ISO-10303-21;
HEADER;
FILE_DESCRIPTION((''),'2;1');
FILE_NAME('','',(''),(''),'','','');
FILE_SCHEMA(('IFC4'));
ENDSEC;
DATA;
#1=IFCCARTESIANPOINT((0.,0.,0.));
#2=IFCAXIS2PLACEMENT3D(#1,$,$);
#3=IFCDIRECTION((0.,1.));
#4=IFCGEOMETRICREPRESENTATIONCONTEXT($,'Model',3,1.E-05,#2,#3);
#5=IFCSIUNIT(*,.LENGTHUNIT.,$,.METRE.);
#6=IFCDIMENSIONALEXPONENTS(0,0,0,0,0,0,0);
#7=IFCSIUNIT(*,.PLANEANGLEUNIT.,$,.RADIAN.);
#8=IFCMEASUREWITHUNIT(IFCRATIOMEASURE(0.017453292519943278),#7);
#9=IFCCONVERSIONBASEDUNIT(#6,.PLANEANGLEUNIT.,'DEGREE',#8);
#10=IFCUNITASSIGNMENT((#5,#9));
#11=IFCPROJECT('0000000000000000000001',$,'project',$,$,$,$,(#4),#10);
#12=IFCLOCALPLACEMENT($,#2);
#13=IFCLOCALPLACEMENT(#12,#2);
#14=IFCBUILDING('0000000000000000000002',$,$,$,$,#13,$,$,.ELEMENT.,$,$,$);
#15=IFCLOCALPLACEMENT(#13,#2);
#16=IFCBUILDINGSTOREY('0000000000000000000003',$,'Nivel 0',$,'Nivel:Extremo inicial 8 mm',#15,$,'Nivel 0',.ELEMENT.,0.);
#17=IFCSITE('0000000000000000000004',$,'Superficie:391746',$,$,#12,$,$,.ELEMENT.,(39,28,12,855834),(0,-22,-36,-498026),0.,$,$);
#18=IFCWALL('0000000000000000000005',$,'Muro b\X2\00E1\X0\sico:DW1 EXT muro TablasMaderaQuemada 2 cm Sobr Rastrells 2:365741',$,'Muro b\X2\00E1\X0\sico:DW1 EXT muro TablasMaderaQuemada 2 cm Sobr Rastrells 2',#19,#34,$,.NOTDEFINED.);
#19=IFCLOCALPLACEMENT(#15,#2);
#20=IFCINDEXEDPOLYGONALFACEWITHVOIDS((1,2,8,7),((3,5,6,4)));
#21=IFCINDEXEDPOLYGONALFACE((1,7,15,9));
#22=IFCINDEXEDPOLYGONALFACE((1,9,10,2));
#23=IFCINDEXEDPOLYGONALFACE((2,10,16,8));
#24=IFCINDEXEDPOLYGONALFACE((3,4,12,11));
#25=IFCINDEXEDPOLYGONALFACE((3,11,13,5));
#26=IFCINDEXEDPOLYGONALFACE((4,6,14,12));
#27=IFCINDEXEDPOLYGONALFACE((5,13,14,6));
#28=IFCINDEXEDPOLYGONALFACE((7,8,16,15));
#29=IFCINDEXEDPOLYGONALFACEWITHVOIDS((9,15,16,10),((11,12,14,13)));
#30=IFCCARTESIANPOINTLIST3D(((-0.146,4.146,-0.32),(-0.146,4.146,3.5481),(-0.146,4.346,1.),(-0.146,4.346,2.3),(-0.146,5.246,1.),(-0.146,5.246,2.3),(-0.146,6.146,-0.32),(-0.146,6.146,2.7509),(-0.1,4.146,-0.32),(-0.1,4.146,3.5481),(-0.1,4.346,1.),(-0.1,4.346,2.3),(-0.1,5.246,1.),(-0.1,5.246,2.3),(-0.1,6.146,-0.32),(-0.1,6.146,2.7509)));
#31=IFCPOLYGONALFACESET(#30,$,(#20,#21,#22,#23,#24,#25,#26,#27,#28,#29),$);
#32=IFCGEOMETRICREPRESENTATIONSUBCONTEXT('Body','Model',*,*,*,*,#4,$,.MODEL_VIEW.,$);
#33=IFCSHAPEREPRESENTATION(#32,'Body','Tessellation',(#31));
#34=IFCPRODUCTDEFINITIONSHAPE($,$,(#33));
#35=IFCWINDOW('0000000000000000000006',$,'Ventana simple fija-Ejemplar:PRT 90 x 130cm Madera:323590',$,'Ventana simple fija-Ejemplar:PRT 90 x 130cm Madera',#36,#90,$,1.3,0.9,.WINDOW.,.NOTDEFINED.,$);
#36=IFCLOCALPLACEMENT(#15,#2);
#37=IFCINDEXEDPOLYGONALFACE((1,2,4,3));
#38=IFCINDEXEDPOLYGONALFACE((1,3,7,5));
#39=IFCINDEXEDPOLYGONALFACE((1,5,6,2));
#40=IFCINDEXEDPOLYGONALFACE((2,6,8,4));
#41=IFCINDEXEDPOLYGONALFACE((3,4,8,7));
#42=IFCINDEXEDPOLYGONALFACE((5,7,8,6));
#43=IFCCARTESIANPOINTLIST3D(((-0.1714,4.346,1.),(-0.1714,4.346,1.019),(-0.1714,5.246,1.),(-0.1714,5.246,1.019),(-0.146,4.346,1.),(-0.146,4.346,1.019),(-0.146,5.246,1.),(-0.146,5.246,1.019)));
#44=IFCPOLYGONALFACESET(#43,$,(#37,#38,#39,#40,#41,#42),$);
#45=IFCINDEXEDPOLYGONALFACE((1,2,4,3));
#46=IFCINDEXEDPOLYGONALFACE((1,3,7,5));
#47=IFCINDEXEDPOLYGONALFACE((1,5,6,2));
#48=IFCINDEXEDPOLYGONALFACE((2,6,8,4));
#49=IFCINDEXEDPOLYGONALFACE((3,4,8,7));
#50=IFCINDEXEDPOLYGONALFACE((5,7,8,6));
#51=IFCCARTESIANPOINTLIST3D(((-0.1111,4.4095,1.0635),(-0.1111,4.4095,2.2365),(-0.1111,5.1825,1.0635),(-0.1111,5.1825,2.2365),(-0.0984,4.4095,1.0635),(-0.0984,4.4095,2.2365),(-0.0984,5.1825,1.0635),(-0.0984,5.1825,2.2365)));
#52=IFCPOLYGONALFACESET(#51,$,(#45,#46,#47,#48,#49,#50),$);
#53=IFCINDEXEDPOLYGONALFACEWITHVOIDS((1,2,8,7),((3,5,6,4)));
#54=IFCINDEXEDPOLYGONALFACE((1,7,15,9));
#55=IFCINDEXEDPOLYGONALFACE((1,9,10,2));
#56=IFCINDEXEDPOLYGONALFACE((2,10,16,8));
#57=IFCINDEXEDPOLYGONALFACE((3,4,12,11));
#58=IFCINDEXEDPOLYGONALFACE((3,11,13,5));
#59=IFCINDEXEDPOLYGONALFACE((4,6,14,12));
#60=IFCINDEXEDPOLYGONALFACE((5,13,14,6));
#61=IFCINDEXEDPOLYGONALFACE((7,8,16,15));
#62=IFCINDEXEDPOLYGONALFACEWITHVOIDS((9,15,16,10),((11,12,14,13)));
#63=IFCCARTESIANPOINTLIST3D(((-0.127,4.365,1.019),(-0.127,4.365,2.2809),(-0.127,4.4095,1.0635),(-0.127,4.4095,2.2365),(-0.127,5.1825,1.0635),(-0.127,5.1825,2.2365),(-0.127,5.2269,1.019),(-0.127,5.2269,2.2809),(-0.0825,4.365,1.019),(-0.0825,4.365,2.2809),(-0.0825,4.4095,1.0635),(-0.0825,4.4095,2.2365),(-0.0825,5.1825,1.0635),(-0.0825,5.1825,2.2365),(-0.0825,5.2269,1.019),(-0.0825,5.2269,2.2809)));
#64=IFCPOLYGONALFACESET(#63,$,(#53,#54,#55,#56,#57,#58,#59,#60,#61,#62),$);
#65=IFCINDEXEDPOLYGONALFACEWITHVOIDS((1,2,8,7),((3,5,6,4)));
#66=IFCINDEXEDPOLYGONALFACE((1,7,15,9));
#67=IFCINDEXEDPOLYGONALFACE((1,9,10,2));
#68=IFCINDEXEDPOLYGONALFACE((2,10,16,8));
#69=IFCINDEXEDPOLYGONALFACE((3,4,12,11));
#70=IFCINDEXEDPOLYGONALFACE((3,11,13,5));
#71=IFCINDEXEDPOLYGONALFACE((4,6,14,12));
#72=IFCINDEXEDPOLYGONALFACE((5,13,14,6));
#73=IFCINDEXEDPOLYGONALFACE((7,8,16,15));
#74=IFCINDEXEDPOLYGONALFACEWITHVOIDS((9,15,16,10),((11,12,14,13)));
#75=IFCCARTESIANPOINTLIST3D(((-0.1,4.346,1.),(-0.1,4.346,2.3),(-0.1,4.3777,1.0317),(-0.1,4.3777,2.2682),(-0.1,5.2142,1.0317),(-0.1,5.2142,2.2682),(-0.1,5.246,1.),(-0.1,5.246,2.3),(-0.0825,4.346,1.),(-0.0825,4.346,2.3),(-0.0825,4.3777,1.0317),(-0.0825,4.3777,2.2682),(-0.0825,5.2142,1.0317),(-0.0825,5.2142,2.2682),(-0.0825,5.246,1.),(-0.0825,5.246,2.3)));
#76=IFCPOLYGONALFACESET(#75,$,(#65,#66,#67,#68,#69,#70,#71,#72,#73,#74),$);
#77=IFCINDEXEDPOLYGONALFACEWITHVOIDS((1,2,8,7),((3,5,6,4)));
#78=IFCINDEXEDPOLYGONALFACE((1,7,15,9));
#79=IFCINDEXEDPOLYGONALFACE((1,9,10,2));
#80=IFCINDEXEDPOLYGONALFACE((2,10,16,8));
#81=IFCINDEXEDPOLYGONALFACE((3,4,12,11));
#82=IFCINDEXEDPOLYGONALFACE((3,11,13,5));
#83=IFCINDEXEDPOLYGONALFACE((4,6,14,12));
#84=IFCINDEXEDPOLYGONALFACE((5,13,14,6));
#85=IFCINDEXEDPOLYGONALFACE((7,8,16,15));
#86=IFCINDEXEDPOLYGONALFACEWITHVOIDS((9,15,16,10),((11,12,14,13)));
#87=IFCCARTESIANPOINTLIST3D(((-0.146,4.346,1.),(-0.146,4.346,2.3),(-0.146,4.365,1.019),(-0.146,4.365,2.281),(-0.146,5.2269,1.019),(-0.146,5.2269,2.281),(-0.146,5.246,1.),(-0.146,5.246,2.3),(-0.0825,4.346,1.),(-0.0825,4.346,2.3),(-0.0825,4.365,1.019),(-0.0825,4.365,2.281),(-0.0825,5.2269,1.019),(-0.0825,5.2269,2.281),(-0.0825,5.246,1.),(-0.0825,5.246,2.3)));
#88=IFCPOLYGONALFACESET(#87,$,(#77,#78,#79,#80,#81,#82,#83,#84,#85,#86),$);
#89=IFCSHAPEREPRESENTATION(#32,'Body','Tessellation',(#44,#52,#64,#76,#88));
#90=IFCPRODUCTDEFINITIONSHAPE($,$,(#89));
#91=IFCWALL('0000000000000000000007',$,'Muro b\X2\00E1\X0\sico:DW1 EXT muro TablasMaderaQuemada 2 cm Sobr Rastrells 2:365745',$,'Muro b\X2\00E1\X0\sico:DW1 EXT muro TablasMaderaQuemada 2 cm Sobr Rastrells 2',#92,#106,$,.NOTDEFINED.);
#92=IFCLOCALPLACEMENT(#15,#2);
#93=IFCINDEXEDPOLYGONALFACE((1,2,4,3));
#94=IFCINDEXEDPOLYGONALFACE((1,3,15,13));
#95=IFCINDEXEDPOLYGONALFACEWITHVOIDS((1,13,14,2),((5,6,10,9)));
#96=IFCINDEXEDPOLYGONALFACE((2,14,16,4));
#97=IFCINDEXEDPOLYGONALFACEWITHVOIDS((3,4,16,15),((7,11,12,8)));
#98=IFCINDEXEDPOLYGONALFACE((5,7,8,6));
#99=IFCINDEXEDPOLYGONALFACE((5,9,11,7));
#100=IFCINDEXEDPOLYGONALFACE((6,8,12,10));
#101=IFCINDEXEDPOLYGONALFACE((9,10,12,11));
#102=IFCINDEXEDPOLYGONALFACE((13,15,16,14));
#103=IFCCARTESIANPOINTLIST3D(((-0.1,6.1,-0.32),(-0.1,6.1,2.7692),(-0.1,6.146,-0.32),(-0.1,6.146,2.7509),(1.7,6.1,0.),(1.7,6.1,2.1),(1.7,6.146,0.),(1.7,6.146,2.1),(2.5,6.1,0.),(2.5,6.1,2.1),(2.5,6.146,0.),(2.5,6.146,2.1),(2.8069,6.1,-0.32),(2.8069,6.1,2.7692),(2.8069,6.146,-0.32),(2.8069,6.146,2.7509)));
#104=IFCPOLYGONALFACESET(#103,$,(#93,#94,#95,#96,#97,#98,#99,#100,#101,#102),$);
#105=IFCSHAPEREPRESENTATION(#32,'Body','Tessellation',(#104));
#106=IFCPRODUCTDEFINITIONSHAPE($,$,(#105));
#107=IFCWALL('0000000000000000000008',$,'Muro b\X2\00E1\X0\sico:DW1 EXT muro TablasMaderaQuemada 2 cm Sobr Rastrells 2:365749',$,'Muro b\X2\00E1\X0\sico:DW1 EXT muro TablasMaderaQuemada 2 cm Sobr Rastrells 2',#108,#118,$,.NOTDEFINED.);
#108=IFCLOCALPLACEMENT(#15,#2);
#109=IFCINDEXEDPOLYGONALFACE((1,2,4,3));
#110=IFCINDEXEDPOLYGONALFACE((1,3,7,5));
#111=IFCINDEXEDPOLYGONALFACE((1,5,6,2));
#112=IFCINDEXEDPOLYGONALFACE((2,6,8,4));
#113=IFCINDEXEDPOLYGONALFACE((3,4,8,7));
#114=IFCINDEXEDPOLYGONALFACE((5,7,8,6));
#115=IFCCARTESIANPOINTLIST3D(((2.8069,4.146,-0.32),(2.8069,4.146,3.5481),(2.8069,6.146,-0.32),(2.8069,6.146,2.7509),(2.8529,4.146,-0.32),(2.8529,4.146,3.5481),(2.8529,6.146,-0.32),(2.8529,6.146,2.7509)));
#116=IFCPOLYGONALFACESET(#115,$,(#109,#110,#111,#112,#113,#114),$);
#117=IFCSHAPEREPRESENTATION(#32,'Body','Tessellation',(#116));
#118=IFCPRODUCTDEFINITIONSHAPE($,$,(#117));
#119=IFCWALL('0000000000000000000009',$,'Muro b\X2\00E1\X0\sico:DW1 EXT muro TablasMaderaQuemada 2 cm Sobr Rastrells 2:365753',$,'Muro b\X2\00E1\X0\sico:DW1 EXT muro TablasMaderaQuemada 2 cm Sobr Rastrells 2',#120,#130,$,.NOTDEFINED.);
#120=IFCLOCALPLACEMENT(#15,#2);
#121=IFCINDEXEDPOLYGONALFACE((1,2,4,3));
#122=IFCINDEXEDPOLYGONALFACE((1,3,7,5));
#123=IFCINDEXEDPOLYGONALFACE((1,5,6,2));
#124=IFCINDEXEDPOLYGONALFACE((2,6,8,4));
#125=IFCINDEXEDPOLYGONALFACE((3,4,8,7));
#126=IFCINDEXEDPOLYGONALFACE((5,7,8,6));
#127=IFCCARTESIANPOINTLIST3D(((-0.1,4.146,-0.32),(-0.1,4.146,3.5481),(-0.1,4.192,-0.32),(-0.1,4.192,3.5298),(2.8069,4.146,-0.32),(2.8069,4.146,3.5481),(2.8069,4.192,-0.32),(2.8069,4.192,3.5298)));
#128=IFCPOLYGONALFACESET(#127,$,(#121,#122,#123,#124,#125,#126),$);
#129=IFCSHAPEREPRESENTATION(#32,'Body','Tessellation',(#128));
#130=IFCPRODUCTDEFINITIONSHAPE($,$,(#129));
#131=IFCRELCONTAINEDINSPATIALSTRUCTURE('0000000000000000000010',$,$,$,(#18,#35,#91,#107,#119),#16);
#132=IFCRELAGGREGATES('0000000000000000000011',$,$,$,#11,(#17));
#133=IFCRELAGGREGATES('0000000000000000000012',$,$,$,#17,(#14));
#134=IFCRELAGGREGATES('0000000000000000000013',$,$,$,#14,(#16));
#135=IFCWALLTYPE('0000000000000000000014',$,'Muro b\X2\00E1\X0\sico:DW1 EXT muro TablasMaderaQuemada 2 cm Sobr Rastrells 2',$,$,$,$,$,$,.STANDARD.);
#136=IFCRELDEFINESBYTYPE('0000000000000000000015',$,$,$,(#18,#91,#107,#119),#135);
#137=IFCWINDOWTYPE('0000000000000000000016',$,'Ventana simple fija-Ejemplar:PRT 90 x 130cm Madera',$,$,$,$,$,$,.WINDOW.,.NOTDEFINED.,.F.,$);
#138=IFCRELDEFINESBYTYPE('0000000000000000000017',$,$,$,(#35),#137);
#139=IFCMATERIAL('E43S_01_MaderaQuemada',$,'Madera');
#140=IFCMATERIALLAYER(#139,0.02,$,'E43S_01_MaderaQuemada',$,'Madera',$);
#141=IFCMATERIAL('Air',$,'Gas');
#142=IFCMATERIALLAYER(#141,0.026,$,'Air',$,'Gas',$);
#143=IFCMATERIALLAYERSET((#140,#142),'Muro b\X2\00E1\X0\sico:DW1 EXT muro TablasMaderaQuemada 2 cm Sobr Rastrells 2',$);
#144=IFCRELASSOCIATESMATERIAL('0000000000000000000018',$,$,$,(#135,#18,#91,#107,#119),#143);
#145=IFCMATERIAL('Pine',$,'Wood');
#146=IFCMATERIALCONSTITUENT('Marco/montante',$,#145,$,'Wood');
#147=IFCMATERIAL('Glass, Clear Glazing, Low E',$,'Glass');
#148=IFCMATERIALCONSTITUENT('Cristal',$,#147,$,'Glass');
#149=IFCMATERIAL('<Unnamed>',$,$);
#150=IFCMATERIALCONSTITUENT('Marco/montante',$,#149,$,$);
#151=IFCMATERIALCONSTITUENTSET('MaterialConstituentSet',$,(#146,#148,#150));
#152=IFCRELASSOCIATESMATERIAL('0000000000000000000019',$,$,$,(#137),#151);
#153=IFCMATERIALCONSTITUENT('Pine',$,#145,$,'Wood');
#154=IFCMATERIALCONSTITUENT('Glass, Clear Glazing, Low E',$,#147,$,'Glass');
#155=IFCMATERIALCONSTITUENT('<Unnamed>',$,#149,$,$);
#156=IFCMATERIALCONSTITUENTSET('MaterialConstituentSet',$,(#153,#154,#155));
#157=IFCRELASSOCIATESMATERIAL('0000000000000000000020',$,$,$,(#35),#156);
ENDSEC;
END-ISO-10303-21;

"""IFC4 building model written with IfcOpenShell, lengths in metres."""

from ifc_helpers import new_model, entity, si_unit, converted_unit, direction, frame, frame_2d, origin, origin_2d_with_axis, place, context, subcontext, project, spatial, polyline, rectangle, outline, extrude, clip, bounded_halfspace, source, transform, mapped, material, layer, layer_set, layer_usage, constituent, constituent_set, type_object, type_shapes, element, fill, save


model = new_model("IFC4")

# Units and contexts
model_context = context("Model", 3, precision=1e-05, world=origin(), true_north=direction((0.0, 1.0)))
body_context = subcontext(model_context, "Body", "Model", "MODEL_VIEW")
ifc_project = project(units=[si_unit("LENGTHUNIT", "METRE"), converted_unit("PLANEANGLEUNIT", "DEGREE", entity("IfcRatioMeasure", 0.017453292519943278), si_unit("PLANEANGLEUNIT", "RADIAN"), dimensions=[0, 0, 0, 0, 0, 0, 0])], contexts=[model_context])

# Site, building, storey
site_placement = place(None, origin())
site = spatial("IfcSite", under=ifc_project, at=site_placement, Name="Superficie:391746", CompositionType="ELEMENT", RefLatitude=(39, 28, 12, 855834), RefLongitude=(0, -22, -36, -498026), RefElevation=0.0)
building_placement = place(site_placement, origin())
building = spatial("IfcBuilding", under=site, at=building_placement, CompositionType="ELEMENT")
storey_placement = place(building_placement, origin())
storey = spatial("IfcBuildingStorey", under=building, at=storey_placement, Name="Nivel 0", ObjectType="Nivel:Extremo inicial 8 mm", LongName="Nivel 0", CompositionType="ELEMENT", Elevation=0.0)

# Shared definitions
ifc_material_1 = material(Name="Pine", Category="Wood")
ifc_material_2 = material(Name="Glass, Clear Glazing, Low E", Category="Glass")
ifc_material_3 = material(Name="<Unnamed>")

# Wall, opening, window
ifc_material_4 = material(Name="E43S_01_MaderaQuemada", Category="Madera")
ifc_layer_1 = layer(ifc_material_4, 0.02, Name="E43S_01_MaderaQuemada", Category="Madera")
ifc_material_5 = material(Name="Air", Category="Gas")
ifc_layer_2 = layer(ifc_material_5, 0.026, Name="Air", Category="Gas")
ifc_layer_set_1 = layer_set([ifc_layer_1, ifc_layer_2], Name="Muro básico:DW1 EXT muro TablasMaderaQuemada 2 cm Sobr Rastrells 2")
ifc_layer_usage_1 = layer_usage(ifc_layer_set_1, "AXIS2", "NEGATIVE", 0.023)
wall_type_1 = type_object("IfcWallType", Name="Muro básico:DW1 EXT muro TablasMaderaQuemada 2 cm Sobr Rastrells 2", PredefinedType="STANDARD", material=ifc_layer_set_1)
wall_1_placement = place(storey_placement, frame((-0.123, 4.146, -0.32), z_axis=(0.0, 0.0, 1.0), x_axis=(0.0, 1.0, 0.0)))
wall_1 = element("IfcWall", 1, at=wall_1_placement, inside=storey, type_object=wall_type_1, material=ifc_layer_usage_1, Name="Muro básico:DW1 EXT muro TablasMaderaQuemada 2 cm Sobr Rastrells 2:365741", ObjectType="Muro básico:DW1 EXT muro TablasMaderaQuemada 2 cm Sobr Rastrells 2", PredefinedType="NOTDEFINED", context=body_context, shape_type="Clipping", body=[
    clip(extrude(rectangle(XDim=2.0, YDim=0.046, at=frame_2d((1.0, 0.0), x_axis=(1.0, 0.0))), origin(), (0.0, 0.0, 1.0), 3.8681), bounded_halfspace(frame((0.0, -0.023, 3.8681), z_axis=(0.370288, 0.0, 0.928917), x_axis=(0.0, 1.0, 0.0)), False, frame((0.0, -0.023, 3.8681)), polyline([(0.0, 0.0), (0.046, 0.0), (1.954, 0.0), (2.0, 0.0), (2.0, 0.046), (0.0, 0.046), (0.0, 0.0)]))),
])
opening_1_placement = place(wall_1_placement, frame((0.2, -0.023, 1.32)))
opening_1 = element("IfcOpeningElement", 2, at=opening_1_placement, cuts=wall_1, PredefinedType="OPENING", context=body_context, shape_type="SweptSolid", body=[
    extrude(rectangle(XDim=1.3, YDim=0.9, at=frame_2d((0.65, 0.45), x_axis=(-1.0, 0.0))), frame((0.0, 0.0, 0.0), z_axis=(0.0, 1.0, 0.0), x_axis=(0.0, 0.0, 1.0)), (0.0, 0.0, 1.0), 0.046),
])
ifc_constituent_1 = constituent(ifc_material_1, Name="Pine", Category="Wood")
ifc_constituent_2 = constituent(ifc_material_2, Name="Glass, Clear Glazing, Low E", Category="Glass")
ifc_constituent_3 = constituent(ifc_material_3, Name="<Unnamed>")
ifc_constituent_set_1 = constituent_set(constituents=[ifc_constituent_1, ifc_constituent_2, ifc_constituent_3], Name="MaterialConstituentSet")
ifc_constituent_4 = constituent(ifc_material_1, Name="Marco/montante", Category="Wood")
ifc_constituent_5 = constituent(ifc_material_2, Name="Cristal", Category="Glass")
ifc_constituent_6 = constituent(ifc_material_3, Name="Marco/montante")
ifc_constituent_set_2 = constituent_set(constituents=[ifc_constituent_4, ifc_constituent_5, ifc_constituent_6], Name="MaterialConstituentSet")
window_type_1 = type_object("IfcWindowType", Name="Ventana simple fija-Ejemplar:PRT 90 x 130cm Madera", ParameterTakesPrecedence=False, PartitioningType="NOTDEFINED", PredefinedType="WINDOW", material=ifc_constituent_set_2)
shared_shape_1 = source(origin(), body_context, "Body", "SweptSolid", [
    extrude(rectangle(XDim=0.9, YDim=0.0254, at=origin_2d_with_axis()), frame((0.5262, 0.0587, 0.0), z_axis=(0.0, 0.0, 1.0), x_axis=(-1.0, 0.0, 0.0)), (0.0, 0.0, 1.0), 0.019),
    extrude(rectangle(XDim=0.773, YDim=0.0127, at=origin_2d_with_axis()), frame((0.5262, 0.0048, 0.0635)), (0.0, 0.0, 1.0), 1.173),
    extrude(outline(polyline([(-0.431, -0.631), (0.431, -0.631), (0.431, 0.631), (-0.431, 0.631), (-0.431, -0.631)]), holes=[polyline([(-0.3865, -0.5865), (-0.3865, 0.5865), (0.3865, 0.5865), (0.3865, -0.5865), (-0.3865, -0.5865)])]), frame((0.5262, 0.027, 0.65), z_axis=(0.0, -1.0, 0.0), x_axis=(-1.0, 0.0, 0.0)), (0.0, 0.0, 1.0), 0.0444),
    extrude(outline(polyline([(-0.45, -0.65), (0.45, -0.65), (0.45, 0.65), (-0.45, 0.65), (-0.45, -0.65)]), holes=[polyline([(-0.4183, -0.6182), (-0.4183, 0.6183), (0.4183, 0.6183), (0.4183, -0.6182), (-0.4183, -0.6182)])]), frame((0.5262, 0.0, 0.65), z_axis=(0.0, -1.0, 0.0), x_axis=(-1.0, 0.0, 0.0)), (0.0, 0.0, 1.0), 0.0175),
    extrude(outline(polyline([(-0.65, -0.45), (0.65, -0.45), (0.65, 0.45), (-0.65, 0.45), (-0.65, -0.45)]), holes=[polyline([(-0.6309, -0.431), (-0.6309, 0.431), (0.631, 0.431), (0.631, -0.431), (-0.6309, -0.431)])]), frame((0.5262, 0.046, 0.65), z_axis=(0.0, -1.0, 0.0), x_axis=(0.0, 0.0, -1.0)), (0.0, 0.0, 1.0), 0.0635),
])
type_shapes(window_type_1, [shared_shape_1])
window_1_placement = place(opening_1_placement, frame((-0.0762, 0.0, 0.0)))
window_1 = element("IfcWindow", 3, at=window_1_placement, inside=storey, type_object=window_type_1, material=ifc_constituent_set_1, Name="Ventana simple fija-Ejemplar:PRT 90 x 130cm Madera:323590", ObjectType="Ventana simple fija-Ejemplar:PRT 90 x 130cm Madera", OverallHeight=1.3, OverallWidth=0.9, PartitioningType="NOTDEFINED", PredefinedType="WINDOW", context=body_context, shape_type="MappedRepresentation", body=[
    mapped(shared_shape_1, transform((0.0, 0.0, 0.0), scale=1.0)),
])
fill(opening_1, window_1)

# Wall, opening
ifc_layer_usage_2 = layer_usage(ifc_layer_set_1, "AXIS2", "NEGATIVE", 0.023)
wall_2_placement = place(storey_placement, frame((-0.1, 6.123, -0.32)))
wall_2 = element("IfcWall", 4, at=wall_2_placement, inside=storey, type_object=wall_type_1, material=ifc_layer_usage_2, Name="Muro básico:DW1 EXT muro TablasMaderaQuemada 2 cm Sobr Rastrells 2:365745", ObjectType="Muro básico:DW1 EXT muro TablasMaderaQuemada 2 cm Sobr Rastrells 2", PredefinedType="NOTDEFINED", context=body_context, shape_type="Clipping", body=[
    clip(extrude(rectangle(XDim=2.9069, YDim=0.046, at=frame_2d((1.4535, 0.0), x_axis=(1.0, 0.0))), origin(), (0.0, 0.0, 1.0), 3.0892), bounded_halfspace(frame((0.0, -0.023, 3.0892), z_axis=(0.0, 0.370288, 0.928917), x_axis=(-1.0, 0.0, 0.0)), False, frame((0.0, -0.023, 3.0892)), polyline([(0.0, 0.0), (2.9069, 0.0), (2.9069, 0.046), (0.0, 0.046), (0.0, 0.0)]))),
])
opening_2_placement = place(wall_2_placement, frame((1.8, -1.547, 0.32)))
element("IfcOpeningElement", 5, at=opening_2_placement, cuts=wall_2, PredefinedType="OPENING", context=body_context, shape_type="SweptSolid", body=[
    extrude(rectangle(XDim=2.1, YDim=0.8, at=frame_2d((0.0, 0.0), x_axis=(1.0, 0.0))), frame((0.4, 0.0, 1.05), z_axis=(0.0, 1.0, 0.0), x_axis=(0.0, 0.0, -1.0)), (0.0, 0.0, 1.0), 3.048),
])

# Walls
ifc_layer_usage_3 = layer_usage(ifc_layer_set_1, "AXIS2", "NEGATIVE", 0.023)
wall_3_placement = place(storey_placement, frame((2.8299, 6.146, -0.32), z_axis=(0.0, 0.0, 1.0), x_axis=(0.0, -1.0, 0.0)))
element("IfcWall", 6, at=wall_3_placement, inside=storey, type_object=wall_type_1, material=ifc_layer_usage_3, Name="Muro básico:DW1 EXT muro TablasMaderaQuemada 2 cm Sobr Rastrells 2:365749", ObjectType="Muro básico:DW1 EXT muro TablasMaderaQuemada 2 cm Sobr Rastrells 2", PredefinedType="NOTDEFINED", context=body_context, shape_type="Clipping", body=[
    clip(extrude(rectangle(XDim=2.0, YDim=0.046, at=frame_2d((1.0, 0.0), x_axis=(-1.0, 0.0))), origin(), (0.0, 0.0, 1.0), 3.8681), bounded_halfspace(frame((0.0, -0.023, 3.0709), z_axis=(-0.370288, 0.0, 0.928917), x_axis=(0.0, -1.0, 0.0)), False, frame((0.0, -0.023, 3.0709)), polyline([(0.0, 0.0), (0.046, 0.0), (1.954, 0.0), (2.0, 0.0), (2.0, 0.046), (0.0, 0.046), (0.0, 0.0)]))),
])
ifc_layer_usage_4 = layer_usage(ifc_layer_set_1, "AXIS2", "NEGATIVE", 0.023)
wall_4_placement = place(storey_placement, frame((2.8069, 4.169, -0.32), z_axis=(0.0, 0.0, 1.0), x_axis=(-1.0, 0.0, 0.0)))
element("IfcWall", 7, at=wall_4_placement, inside=storey, type_object=wall_type_1, material=ifc_layer_usage_4, Name="Muro básico:DW1 EXT muro TablasMaderaQuemada 2 cm Sobr Rastrells 2:365753", ObjectType="Muro básico:DW1 EXT muro TablasMaderaQuemada 2 cm Sobr Rastrells 2", PredefinedType="NOTDEFINED", context=body_context, shape_type="Clipping", body=[
    clip(extrude(rectangle(XDim=2.9069, YDim=0.046, at=frame_2d((1.4535, 0.0), x_axis=(-1.0, 0.0))), origin(), (0.0, 0.0, 1.0), 3.8681), bounded_halfspace(frame((0.0, -0.023, 3.8498), z_axis=(0.0, -0.370288, 0.928917), x_axis=(1.0, 0.0, 0.0)), False, frame((0.0, -0.023, 3.8498)), polyline([(0.0, 0.0), (0.2, 0.0), (2.7069, 0.0), (2.8069, 0.0), (2.9069, 0.0), (2.9069, 0.046), (0.0, 0.046), (0.0, 0.0)]))),
])

save(model, "model.ifc")
